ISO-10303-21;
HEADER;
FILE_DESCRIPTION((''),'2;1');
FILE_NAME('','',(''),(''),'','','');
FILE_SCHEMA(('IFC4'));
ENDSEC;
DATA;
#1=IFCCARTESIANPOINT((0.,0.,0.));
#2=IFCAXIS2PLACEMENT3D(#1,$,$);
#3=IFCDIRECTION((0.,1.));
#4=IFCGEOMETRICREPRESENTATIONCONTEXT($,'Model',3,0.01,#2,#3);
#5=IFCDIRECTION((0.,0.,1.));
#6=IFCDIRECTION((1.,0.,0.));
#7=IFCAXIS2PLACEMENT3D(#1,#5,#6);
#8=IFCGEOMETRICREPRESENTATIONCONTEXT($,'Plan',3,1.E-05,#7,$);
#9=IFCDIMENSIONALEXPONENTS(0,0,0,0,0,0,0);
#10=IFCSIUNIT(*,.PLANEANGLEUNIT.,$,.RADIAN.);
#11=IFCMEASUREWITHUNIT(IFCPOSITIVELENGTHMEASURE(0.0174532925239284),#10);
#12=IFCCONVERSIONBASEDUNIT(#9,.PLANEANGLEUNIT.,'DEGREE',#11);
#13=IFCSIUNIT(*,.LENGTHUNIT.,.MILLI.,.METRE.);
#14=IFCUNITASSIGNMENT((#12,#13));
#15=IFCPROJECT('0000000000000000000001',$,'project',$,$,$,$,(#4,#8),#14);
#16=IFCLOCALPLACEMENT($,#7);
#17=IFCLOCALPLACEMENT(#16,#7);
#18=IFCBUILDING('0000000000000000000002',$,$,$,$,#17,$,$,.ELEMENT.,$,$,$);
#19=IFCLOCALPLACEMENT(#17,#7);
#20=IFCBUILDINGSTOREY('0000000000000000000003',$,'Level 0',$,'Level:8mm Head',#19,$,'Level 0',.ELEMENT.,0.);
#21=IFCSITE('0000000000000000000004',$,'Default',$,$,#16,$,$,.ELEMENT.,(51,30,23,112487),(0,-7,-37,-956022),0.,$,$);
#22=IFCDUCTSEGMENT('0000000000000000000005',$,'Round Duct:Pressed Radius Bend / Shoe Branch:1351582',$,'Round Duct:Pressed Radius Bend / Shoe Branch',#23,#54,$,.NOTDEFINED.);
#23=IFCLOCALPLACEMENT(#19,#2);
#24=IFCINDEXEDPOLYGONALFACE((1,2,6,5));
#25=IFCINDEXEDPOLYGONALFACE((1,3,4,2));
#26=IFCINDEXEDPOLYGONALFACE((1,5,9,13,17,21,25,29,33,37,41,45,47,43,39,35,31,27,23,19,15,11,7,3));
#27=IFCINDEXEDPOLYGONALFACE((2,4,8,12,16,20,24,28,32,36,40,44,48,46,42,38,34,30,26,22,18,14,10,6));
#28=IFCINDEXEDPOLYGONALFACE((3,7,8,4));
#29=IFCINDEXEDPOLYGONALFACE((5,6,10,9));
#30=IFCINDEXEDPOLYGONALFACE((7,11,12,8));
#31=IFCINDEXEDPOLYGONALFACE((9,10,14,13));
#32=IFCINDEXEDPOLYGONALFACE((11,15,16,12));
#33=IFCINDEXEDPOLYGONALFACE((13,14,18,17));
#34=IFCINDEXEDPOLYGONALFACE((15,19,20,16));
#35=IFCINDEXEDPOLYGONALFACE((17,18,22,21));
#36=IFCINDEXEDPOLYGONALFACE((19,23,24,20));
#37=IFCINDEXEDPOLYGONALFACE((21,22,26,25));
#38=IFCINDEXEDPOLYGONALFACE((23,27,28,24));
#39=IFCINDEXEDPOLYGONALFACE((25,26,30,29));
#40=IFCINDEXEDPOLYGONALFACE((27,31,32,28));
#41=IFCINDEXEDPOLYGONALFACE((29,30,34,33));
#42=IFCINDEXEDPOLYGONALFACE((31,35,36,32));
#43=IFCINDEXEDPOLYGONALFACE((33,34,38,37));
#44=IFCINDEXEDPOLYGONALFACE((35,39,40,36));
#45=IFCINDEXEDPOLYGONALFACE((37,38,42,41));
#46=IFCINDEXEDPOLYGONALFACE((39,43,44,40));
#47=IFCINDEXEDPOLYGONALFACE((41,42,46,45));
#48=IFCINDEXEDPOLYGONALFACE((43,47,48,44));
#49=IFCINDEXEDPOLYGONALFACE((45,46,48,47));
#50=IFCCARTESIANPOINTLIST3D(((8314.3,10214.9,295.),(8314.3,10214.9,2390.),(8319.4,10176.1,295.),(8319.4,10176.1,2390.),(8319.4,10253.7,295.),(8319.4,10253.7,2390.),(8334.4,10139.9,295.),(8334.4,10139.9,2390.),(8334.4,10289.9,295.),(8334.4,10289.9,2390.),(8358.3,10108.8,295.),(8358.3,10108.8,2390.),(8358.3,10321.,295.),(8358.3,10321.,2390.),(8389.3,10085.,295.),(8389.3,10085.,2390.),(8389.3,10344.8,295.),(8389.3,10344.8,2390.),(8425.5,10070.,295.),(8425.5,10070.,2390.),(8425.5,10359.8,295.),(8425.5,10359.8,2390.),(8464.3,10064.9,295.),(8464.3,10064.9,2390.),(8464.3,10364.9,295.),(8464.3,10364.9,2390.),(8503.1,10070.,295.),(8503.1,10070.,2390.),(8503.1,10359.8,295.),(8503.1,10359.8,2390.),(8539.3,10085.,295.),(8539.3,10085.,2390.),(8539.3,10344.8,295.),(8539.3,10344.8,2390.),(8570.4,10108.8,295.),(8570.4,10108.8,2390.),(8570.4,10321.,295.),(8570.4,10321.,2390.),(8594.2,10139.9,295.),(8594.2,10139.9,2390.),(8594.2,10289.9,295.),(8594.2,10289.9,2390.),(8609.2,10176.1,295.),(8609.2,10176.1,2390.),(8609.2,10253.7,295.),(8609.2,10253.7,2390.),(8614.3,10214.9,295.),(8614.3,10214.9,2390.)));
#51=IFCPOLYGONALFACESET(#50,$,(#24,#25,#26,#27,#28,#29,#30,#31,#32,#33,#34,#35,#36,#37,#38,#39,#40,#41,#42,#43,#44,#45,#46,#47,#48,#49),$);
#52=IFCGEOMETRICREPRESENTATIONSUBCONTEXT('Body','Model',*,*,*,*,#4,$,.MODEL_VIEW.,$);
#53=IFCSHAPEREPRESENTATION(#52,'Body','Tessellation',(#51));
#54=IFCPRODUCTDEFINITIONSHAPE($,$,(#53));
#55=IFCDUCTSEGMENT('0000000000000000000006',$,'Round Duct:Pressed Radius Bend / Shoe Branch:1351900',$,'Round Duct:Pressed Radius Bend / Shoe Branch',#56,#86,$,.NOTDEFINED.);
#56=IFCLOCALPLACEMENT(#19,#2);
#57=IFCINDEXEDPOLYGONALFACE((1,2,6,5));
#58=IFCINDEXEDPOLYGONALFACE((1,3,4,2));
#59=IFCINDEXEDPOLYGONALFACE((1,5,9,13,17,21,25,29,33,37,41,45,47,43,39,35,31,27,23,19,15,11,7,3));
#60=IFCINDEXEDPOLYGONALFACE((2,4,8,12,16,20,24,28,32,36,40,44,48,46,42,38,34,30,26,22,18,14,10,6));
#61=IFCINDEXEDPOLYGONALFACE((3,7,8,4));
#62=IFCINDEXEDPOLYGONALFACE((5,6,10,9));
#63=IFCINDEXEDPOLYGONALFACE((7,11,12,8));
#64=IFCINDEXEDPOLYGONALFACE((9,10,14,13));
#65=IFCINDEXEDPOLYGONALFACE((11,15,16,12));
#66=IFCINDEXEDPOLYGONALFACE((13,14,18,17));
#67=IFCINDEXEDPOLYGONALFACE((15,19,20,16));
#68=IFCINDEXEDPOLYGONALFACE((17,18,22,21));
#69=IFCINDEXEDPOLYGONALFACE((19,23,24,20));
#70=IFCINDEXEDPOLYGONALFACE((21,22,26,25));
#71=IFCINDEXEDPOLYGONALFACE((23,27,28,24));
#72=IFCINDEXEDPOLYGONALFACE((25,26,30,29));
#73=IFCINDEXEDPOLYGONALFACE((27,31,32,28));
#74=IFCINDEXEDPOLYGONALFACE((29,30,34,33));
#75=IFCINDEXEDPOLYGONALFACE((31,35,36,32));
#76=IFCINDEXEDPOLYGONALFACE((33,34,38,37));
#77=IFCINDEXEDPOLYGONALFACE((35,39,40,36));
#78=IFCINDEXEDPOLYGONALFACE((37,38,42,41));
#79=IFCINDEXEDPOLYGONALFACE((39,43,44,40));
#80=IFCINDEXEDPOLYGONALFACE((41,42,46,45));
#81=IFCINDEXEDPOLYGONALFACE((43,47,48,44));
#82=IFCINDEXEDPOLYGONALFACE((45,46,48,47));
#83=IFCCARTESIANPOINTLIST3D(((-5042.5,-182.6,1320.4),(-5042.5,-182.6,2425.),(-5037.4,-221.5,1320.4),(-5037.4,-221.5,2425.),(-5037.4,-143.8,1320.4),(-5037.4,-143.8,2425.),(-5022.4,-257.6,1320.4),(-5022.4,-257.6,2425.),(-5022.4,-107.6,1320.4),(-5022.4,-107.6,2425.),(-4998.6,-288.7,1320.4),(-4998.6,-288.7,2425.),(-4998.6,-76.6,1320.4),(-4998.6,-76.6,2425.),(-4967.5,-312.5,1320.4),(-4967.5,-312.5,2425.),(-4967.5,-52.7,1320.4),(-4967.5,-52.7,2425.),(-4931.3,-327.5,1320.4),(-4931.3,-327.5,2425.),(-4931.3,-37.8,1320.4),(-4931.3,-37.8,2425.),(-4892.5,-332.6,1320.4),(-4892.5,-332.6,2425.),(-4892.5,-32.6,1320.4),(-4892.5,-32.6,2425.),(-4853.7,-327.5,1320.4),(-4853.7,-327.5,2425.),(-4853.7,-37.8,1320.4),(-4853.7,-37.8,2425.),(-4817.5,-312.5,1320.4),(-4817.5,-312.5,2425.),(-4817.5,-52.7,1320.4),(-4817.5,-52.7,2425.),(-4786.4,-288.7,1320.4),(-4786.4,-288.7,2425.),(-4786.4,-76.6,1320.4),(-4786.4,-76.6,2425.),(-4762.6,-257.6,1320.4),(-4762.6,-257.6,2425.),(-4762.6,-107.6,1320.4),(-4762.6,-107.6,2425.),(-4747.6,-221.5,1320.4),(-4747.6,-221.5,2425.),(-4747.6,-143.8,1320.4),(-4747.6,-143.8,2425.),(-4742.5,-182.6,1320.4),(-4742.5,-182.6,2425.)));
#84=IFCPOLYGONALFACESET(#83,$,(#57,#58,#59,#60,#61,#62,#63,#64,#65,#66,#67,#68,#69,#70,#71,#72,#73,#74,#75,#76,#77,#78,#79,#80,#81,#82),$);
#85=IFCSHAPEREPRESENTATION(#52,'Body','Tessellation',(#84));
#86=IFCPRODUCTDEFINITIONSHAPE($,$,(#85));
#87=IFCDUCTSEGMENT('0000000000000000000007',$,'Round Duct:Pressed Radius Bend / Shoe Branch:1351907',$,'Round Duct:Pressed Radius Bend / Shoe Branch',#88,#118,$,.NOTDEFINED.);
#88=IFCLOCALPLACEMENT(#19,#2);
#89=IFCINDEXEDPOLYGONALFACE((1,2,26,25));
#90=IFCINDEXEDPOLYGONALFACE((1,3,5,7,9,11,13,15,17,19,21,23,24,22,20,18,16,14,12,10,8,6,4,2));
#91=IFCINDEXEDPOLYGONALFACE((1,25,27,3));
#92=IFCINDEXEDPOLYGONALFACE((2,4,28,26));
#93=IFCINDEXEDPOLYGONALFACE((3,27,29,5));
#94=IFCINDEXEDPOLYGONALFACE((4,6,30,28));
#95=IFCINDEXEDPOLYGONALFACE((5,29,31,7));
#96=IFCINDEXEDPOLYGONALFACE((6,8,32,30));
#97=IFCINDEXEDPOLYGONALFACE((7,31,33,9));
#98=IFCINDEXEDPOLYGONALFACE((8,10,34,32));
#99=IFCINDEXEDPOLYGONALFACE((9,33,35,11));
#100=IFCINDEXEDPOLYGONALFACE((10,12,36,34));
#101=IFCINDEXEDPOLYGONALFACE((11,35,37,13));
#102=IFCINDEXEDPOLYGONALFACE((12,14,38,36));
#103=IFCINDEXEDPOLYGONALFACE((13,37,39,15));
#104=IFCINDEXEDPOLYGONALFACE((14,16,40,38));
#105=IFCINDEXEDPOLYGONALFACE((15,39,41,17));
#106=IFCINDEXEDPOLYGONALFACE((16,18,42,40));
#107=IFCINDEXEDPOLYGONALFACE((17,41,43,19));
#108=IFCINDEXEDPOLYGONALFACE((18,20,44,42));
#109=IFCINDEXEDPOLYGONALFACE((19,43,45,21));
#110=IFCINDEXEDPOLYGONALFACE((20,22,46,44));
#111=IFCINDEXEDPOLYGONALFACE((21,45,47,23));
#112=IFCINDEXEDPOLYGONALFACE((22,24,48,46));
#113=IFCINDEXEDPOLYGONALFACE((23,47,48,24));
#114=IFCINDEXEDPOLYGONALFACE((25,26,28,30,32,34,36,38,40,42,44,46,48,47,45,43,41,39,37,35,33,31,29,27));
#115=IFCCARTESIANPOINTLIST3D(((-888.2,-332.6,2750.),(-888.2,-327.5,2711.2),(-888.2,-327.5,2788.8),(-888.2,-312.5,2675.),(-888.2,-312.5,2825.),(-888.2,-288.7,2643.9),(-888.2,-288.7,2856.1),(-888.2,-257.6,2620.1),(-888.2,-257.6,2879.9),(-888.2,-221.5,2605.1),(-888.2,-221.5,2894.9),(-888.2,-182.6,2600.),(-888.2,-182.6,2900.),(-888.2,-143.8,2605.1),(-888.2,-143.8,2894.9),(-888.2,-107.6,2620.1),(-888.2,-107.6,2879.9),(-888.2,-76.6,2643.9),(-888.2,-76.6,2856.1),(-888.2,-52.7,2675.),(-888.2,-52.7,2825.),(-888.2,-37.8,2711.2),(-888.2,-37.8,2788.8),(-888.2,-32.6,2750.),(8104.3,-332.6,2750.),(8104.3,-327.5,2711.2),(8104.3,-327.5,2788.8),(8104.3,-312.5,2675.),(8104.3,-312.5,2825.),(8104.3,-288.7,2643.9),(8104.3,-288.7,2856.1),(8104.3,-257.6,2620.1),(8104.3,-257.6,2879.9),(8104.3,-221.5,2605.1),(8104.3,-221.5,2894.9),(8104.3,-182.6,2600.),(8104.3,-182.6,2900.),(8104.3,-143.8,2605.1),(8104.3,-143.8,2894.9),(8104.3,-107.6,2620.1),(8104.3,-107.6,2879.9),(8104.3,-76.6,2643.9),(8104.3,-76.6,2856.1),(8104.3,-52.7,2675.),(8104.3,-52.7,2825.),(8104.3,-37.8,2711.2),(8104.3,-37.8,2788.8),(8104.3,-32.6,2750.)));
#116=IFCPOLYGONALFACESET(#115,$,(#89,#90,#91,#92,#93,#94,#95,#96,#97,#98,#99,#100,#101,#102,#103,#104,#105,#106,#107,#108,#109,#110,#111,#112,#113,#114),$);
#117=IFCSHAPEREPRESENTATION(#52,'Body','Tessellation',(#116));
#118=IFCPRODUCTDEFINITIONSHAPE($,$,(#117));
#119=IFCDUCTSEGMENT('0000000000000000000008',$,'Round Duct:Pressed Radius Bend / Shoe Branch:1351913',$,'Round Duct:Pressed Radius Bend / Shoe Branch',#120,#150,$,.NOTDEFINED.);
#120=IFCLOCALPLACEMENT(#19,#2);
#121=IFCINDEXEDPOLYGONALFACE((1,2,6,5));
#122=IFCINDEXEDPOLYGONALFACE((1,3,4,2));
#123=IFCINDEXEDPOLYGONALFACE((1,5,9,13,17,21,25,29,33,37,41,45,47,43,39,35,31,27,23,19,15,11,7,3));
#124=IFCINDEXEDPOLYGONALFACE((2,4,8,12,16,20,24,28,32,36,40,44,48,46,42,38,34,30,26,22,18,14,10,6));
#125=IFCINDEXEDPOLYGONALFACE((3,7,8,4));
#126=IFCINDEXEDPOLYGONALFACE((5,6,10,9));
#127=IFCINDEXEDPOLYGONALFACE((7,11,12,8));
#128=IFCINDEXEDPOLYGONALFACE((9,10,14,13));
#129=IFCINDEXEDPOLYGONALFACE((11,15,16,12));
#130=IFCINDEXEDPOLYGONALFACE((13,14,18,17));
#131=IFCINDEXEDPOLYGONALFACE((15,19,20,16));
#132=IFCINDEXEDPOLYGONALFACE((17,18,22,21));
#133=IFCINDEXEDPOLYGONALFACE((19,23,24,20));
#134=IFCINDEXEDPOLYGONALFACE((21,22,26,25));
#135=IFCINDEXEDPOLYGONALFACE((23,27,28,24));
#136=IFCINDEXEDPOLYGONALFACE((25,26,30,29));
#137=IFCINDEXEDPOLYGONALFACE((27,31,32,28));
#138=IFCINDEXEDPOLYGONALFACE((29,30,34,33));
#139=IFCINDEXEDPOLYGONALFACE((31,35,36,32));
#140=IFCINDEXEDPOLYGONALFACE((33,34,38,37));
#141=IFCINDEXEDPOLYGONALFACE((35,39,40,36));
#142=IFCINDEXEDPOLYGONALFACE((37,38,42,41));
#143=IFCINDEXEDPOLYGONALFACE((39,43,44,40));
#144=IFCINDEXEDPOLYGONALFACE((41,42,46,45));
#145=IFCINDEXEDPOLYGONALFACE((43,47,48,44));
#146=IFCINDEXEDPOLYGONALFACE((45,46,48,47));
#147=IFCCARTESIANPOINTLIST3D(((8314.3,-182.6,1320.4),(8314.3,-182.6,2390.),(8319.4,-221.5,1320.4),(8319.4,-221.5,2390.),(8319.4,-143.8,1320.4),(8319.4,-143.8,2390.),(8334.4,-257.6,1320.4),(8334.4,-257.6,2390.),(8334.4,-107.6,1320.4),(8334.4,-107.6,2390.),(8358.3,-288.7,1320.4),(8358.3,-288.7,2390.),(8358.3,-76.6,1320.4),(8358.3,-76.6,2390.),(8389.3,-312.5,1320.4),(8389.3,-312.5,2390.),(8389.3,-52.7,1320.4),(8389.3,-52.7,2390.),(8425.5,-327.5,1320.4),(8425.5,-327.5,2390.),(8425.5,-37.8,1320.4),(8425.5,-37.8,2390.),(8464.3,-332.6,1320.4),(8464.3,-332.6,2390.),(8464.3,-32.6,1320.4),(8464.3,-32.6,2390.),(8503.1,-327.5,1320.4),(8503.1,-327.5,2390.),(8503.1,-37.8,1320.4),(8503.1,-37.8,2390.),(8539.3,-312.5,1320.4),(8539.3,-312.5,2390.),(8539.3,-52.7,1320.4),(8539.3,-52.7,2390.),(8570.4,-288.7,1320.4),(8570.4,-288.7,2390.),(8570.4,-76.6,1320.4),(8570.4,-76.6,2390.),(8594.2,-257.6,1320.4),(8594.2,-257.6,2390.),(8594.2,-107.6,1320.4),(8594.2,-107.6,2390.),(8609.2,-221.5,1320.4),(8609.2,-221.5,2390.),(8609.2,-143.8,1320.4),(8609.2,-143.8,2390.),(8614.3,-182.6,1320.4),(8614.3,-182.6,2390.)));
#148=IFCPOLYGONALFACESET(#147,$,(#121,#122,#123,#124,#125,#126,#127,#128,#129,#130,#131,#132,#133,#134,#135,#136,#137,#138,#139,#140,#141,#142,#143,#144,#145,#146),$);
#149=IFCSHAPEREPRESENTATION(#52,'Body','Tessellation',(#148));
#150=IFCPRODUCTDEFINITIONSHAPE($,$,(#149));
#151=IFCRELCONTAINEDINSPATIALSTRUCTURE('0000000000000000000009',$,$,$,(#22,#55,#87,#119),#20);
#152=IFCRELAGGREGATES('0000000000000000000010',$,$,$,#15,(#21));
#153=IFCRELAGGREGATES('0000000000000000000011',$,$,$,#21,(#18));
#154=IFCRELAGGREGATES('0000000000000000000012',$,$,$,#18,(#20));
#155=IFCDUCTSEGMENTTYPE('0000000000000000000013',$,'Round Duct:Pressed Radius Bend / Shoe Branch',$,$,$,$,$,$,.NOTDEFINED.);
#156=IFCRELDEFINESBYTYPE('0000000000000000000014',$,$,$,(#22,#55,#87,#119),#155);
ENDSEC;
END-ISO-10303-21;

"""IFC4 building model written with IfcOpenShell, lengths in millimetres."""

from ifc_helpers import new_model, entity, si_unit, converted_unit, direction, frame, origin, origin_with_axes, place, context, subcontext, project, spatial, arc, indexed_curve, outline, extrude, type_object, element, save


model = new_model("IFC4")

# Units and contexts
model_context = context("Model", 3, precision=0.01, world=origin(), true_north=direction((0.0, 1.0)))
plan_context = context("Plan", 3, precision=1e-05, world=origin_with_axes())
body_context = subcontext(model_context, "Body", "Model", "MODEL_VIEW")
ifc_project = project(units=[converted_unit("PLANEANGLEUNIT", "DEGREE", entity("IfcPositiveLengthMeasure", 0.0174532925239284), si_unit("PLANEANGLEUNIT", "RADIAN"), dimensions=[0, 0, 0, 0, 0, 0, 0]), si_unit("LENGTHUNIT", "METRE", prefix="MILLI")], contexts=[model_context, plan_context])

# Site, building, storey
site_placement = place(None, origin_with_axes())
site = spatial("IfcSite", under=ifc_project, at=site_placement, Name="Default", CompositionType="ELEMENT", RefLatitude=(51, 30, 23, 112487), RefLongitude=(0, -7, -37, -956022), RefElevation=0.0)
building_placement = place(site_placement, origin_with_axes())
building = spatial("IfcBuilding", under=site, at=building_placement, CompositionType="ELEMENT")
storey_placement = place(building_placement, origin_with_axes())
storey = spatial("IfcBuildingStorey", under=building, at=storey_placement, Name="Level 0", ObjectType="Level:8mm Head", LongName="Level 0", CompositionType="ELEMENT", Elevation=0.0)

# Duct segments
duct_segment_type_1 = type_object("IfcDuctSegmentType", Name="Round Duct:Pressed Radius Bend / Shoe Branch", PredefinedType="NOTDEFINED")
duct_segment_1_placement = place(storey_placement, origin_with_axes())
element("IfcDuctSegment", 1, at=duct_segment_1_placement, inside=storey, type_object=duct_segment_type_1, Name="Round Duct:Pressed Radius Bend / Shoe Branch:1351582", ObjectType="Round Duct:Pressed Radius Bend / Shoe Branch", PredefinedType="NOTDEFINED", context=body_context, shape_type="SweptSolid", body=[
    extrude(outline(indexed_curve([(150.0, 0.0), (106.1, 106.1), (0.0, 150.0), (-106.1, 106.1), (-150.0, 0.0), (-106.1, -106.1), (0.0, -150.0), (106.1, -106.1)], segments=[arc(1, 2, 3), arc(3, 4, 5), arc(5, 6, 7), arc(7, 8, 1)], self_intersect=False)), frame((8464.3, 10214.9, 295.0)), (0.0, 0.0, 1.0), 2095.0),
])
duct_segment_2_placement = place(storey_placement, origin_with_axes())
element("IfcDuctSegment", 2, at=duct_segment_2_placement, inside=storey, type_object=duct_segment_type_1, Name="Round Duct:Pressed Radius Bend / Shoe Branch:1351900", ObjectType="Round Duct:Pressed Radius Bend / Shoe Branch", PredefinedType="NOTDEFINED", context=body_context, shape_type="SweptSolid", body=[
    extrude(outline(indexed_curve([(150.0, 0.0), (106.1, 106.1), (0.0, 150.0), (-106.1, 106.1), (-150.0, 0.0), (-106.1, -106.1), (0.0, -150.0), (106.1, -106.1)], segments=[arc(1, 2, 3), arc(3, 4, 5), arc(5, 6, 7), arc(7, 8, 1)], self_intersect=False)), frame((-4892.5, -182.6, 1320.4)), (0.0, 0.0, 1.0), 1104.6),
])
duct_segment_3_placement = place(storey_placement, origin_with_axes())
element("IfcDuctSegment", 3, at=duct_segment_3_placement, inside=storey, type_object=duct_segment_type_1, Name="Round Duct:Pressed Radius Bend / Shoe Branch:1351907", ObjectType="Round Duct:Pressed Radius Bend / Shoe Branch", PredefinedType="NOTDEFINED", context=body_context, shape_type="SweptSolid", body=[
    extrude(outline(indexed_curve([(150.0, 0.0), (106.1, 106.1), (0.0, 150.0), (-106.1, 106.1), (-150.0, 0.0), (-106.1, -106.1), (0.0, -150.0), (106.1, -106.1)], segments=[arc(1, 2, 3), arc(3, 4, 5), arc(5, 6, 7), arc(7, 8, 1)], self_intersect=False)), frame((-888.2, -182.6, 2750.0), z_axis=(1.0, 0.0, 0.0), x_axis=(0.0, 1.0, 0.0)), (0.0, 0.0, 1.0), 8992.6),
])
duct_segment_4_placement = place(storey_placement, origin_with_axes())
element("IfcDuctSegment", 4, at=duct_segment_4_placement, inside=storey, type_object=duct_segment_type_1, Name="Round Duct:Pressed Radius Bend / Shoe Branch:1351913", ObjectType="Round Duct:Pressed Radius Bend / Shoe Branch", PredefinedType="NOTDEFINED", context=body_context, shape_type="SweptSolid", body=[
    extrude(outline(indexed_curve([(150.0, 0.0), (106.1, 106.1), (0.0, 150.0), (-106.1, 106.1), (-150.0, 0.0), (-106.1, -106.1), (0.0, -150.0), (106.1, -106.1)], segments=[arc(1, 2, 3), arc(3, 4, 5), arc(5, 6, 7), arc(7, 8, 1)], self_intersect=False)), frame((8464.3, -182.6, 1320.4), z_axis=(0.0, 0.0, 1.0), x_axis=(-1.0, 0.0, 0.0)), (0.0, 0.0, 1.0), 1069.6),
])

save(model, "model.ifc")
